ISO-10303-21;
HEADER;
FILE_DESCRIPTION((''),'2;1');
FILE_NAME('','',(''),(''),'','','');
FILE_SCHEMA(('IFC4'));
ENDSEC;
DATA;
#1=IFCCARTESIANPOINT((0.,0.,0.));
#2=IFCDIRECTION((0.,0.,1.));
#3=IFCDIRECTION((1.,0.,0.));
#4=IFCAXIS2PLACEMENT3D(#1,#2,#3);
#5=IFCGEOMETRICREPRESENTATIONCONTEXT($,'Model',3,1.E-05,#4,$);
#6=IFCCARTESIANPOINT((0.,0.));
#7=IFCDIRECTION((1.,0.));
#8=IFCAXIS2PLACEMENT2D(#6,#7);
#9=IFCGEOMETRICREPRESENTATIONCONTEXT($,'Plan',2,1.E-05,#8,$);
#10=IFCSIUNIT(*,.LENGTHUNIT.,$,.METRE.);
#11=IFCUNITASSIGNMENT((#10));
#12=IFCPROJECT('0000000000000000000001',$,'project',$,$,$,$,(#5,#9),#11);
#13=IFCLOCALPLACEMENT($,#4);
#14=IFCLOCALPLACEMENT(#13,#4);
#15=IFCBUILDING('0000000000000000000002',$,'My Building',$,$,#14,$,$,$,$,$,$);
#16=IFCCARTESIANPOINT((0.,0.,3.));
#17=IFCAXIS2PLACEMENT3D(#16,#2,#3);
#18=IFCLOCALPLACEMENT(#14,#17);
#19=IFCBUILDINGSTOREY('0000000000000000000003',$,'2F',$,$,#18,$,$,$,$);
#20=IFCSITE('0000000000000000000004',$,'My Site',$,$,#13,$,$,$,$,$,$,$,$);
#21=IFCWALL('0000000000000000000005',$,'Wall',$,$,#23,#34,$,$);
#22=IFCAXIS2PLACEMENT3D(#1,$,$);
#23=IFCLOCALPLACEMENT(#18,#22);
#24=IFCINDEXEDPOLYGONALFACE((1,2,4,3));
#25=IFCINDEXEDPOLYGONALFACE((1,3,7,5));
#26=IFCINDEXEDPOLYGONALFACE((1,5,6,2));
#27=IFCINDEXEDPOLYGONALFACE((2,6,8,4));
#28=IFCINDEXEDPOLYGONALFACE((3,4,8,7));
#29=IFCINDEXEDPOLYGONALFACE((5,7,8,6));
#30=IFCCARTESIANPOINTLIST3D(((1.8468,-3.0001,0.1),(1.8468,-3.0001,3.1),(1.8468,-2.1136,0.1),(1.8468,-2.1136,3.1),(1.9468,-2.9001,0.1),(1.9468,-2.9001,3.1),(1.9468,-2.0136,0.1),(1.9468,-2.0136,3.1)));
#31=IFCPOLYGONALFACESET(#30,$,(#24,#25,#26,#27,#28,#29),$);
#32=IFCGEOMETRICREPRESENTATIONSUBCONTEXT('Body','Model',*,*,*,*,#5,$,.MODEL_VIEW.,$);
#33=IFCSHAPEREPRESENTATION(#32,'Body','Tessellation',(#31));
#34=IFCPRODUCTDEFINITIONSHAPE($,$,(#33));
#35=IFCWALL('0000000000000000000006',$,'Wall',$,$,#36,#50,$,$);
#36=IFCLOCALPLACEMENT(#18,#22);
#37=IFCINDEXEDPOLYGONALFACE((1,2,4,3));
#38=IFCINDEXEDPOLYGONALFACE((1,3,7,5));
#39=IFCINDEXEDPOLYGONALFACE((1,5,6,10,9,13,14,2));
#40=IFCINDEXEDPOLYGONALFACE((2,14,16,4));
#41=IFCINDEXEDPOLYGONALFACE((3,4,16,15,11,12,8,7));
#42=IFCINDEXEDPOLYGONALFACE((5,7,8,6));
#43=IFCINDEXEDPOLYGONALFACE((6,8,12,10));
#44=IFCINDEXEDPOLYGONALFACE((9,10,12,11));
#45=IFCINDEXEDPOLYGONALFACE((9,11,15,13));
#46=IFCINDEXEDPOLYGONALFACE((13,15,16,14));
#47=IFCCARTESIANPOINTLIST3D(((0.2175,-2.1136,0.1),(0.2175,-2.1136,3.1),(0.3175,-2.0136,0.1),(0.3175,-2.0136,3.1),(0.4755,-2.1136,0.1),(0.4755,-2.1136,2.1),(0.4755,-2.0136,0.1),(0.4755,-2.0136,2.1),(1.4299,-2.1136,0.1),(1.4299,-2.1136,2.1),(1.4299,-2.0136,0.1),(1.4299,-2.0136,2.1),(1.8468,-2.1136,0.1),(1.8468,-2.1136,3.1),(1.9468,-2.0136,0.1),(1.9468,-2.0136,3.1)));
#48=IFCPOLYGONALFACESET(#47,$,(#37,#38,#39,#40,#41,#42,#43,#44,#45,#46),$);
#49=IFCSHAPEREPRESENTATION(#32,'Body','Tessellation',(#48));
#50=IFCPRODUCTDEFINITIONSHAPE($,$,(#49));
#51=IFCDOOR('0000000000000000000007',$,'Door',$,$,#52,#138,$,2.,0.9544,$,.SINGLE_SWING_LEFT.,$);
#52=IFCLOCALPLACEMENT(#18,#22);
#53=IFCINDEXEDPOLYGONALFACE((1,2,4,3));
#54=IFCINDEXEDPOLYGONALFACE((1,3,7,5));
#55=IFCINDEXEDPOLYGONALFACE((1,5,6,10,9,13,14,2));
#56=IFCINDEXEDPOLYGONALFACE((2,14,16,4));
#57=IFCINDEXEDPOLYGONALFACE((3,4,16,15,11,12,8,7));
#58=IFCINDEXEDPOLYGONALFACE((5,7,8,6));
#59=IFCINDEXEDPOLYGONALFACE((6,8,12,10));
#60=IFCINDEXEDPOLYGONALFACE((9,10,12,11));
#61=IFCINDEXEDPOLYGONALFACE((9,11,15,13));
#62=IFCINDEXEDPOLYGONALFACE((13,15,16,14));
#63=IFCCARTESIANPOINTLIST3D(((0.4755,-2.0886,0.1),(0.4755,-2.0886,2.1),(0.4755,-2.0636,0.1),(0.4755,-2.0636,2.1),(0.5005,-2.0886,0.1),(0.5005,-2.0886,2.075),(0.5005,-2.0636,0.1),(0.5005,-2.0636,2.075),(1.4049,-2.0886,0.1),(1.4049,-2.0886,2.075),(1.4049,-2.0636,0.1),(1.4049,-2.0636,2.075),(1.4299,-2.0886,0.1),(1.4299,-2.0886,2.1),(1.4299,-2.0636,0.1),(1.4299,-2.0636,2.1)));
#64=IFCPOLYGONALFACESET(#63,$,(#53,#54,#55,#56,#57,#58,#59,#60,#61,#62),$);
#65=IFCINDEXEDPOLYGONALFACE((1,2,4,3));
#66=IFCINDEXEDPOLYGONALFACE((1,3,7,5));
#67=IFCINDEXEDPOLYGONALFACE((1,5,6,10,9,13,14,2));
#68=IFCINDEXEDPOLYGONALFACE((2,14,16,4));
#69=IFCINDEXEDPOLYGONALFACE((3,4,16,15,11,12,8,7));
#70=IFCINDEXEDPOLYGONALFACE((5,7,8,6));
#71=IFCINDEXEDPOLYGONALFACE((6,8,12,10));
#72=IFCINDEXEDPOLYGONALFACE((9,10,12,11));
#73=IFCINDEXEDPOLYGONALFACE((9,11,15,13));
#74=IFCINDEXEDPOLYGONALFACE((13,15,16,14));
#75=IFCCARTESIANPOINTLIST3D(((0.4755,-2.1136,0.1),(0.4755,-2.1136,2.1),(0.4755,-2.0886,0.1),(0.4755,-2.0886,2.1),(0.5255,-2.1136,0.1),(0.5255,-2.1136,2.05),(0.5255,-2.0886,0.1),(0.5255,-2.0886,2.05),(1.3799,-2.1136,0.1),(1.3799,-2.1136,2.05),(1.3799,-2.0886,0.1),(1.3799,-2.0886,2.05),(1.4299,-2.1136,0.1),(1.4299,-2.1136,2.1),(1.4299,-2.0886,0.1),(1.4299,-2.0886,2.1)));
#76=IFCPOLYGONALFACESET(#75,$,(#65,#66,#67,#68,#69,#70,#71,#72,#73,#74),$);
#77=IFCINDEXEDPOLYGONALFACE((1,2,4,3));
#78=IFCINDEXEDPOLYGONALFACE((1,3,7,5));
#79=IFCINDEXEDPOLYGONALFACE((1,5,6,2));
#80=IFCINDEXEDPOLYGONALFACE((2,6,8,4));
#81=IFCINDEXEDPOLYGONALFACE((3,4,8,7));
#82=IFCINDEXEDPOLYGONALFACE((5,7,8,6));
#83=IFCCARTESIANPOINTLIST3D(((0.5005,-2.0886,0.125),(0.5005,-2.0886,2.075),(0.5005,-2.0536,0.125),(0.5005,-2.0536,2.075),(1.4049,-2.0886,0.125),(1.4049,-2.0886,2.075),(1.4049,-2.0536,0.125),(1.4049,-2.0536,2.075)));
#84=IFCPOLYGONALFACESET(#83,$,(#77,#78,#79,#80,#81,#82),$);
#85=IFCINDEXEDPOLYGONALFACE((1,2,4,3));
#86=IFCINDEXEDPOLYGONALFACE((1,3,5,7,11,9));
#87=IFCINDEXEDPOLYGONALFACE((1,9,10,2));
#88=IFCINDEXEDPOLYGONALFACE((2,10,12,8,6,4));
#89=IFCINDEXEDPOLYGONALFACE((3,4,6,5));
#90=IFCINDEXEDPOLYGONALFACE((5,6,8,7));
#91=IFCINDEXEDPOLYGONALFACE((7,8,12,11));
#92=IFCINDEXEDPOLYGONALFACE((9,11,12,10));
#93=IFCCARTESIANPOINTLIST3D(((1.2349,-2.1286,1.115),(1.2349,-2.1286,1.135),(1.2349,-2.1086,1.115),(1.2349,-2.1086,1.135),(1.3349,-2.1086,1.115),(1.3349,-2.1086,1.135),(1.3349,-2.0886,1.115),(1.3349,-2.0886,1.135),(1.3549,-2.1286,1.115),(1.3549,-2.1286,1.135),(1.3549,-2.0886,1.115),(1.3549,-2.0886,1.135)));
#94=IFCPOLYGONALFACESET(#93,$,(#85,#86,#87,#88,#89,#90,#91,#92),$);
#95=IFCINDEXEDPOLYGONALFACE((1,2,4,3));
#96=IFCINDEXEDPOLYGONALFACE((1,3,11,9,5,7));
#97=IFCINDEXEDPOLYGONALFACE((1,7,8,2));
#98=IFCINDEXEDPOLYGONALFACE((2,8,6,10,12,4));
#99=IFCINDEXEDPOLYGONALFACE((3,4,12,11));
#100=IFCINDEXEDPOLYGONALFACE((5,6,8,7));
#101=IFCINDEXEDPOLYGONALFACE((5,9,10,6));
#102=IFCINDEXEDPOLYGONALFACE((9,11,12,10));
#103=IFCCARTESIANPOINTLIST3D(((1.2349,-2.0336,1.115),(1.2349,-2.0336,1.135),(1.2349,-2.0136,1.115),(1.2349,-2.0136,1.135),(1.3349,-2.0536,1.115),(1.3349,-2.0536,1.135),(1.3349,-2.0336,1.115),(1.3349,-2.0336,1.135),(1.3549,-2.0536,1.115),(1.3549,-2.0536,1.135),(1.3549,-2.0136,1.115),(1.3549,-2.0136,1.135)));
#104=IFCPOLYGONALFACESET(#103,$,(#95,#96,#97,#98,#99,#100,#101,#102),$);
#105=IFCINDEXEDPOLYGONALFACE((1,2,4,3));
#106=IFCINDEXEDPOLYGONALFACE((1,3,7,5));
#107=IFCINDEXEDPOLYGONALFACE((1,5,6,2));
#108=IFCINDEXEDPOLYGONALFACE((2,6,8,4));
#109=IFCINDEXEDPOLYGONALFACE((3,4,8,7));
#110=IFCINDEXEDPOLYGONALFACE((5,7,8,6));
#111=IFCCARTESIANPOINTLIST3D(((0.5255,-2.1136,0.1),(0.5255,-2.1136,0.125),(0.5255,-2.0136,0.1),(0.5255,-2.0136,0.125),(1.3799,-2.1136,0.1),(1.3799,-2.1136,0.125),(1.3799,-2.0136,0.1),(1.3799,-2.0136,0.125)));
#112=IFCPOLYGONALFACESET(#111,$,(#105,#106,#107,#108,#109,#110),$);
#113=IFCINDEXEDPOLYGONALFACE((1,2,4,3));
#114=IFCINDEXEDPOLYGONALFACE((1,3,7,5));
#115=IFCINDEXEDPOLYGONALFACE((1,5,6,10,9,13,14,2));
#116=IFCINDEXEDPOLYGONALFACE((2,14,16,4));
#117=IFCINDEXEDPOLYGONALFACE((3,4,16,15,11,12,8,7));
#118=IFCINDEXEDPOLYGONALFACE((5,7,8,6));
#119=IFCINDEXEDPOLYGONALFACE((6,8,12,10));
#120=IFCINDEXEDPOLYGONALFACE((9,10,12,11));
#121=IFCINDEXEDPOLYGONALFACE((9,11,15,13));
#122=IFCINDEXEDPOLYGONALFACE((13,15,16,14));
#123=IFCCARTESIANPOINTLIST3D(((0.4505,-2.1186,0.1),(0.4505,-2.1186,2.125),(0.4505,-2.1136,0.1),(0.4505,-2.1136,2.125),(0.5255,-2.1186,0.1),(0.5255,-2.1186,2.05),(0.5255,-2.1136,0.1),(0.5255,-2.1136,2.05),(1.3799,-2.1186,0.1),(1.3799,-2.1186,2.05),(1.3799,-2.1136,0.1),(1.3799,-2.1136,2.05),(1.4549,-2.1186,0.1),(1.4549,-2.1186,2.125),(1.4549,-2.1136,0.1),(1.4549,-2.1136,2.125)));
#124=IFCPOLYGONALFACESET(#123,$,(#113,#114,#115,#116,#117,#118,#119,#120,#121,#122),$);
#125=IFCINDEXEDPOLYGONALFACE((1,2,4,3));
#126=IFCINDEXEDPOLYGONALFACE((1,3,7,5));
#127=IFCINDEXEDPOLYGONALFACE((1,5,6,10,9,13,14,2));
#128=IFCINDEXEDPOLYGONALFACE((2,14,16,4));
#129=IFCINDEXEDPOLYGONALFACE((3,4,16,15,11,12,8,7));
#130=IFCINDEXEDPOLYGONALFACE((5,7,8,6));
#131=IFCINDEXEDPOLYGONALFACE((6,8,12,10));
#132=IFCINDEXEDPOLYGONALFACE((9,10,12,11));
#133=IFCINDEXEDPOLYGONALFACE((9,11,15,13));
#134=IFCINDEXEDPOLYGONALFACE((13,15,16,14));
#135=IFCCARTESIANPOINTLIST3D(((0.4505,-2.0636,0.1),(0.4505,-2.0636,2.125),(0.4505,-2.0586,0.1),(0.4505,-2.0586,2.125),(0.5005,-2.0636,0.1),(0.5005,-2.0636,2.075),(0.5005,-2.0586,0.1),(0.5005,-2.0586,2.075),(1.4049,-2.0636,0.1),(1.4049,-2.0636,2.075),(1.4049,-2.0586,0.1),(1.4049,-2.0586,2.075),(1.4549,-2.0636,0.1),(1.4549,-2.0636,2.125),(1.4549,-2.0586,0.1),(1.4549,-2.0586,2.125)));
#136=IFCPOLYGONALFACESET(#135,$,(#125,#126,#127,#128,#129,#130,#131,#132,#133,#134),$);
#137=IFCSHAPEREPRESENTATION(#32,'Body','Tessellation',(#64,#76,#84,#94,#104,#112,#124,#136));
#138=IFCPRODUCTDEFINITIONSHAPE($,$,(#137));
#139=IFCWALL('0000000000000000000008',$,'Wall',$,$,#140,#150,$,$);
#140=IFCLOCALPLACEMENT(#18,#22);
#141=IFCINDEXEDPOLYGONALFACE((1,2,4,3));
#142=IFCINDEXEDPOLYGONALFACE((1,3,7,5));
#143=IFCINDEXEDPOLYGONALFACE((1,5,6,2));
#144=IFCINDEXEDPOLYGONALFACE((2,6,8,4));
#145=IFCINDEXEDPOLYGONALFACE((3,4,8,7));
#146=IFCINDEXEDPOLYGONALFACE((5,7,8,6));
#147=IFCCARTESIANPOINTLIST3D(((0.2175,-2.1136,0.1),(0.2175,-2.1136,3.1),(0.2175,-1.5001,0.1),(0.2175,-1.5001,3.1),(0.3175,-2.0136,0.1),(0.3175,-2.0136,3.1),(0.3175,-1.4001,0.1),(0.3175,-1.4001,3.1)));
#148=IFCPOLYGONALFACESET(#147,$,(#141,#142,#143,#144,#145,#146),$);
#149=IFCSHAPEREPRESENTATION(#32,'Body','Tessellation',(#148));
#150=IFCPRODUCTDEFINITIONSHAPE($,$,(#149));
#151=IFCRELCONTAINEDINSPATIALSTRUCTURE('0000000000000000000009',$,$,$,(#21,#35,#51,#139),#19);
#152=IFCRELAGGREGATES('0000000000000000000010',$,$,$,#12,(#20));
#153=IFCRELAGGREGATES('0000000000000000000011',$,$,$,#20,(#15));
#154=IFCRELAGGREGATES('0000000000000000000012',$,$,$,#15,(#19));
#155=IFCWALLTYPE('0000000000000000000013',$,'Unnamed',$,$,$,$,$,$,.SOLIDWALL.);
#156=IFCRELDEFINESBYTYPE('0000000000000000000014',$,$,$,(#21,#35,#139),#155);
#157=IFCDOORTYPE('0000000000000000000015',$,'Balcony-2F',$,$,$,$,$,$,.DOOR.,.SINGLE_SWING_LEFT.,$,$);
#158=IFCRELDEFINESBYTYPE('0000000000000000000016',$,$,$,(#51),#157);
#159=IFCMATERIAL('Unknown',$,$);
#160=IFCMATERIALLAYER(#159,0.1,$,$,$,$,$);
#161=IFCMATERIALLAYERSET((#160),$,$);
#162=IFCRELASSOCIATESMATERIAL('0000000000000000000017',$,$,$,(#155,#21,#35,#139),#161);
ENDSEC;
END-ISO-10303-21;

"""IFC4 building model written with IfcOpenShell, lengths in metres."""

from ifc_helpers import new_model, entity, si_unit, frame, origin_with_axes, origin_2d_with_axis, place, context, subcontext, project, spatial, line, indexed_curve, outline, extrude, shape, source, transform, mapped, material, layer, layer_set, layer_usage, type_object, type_shapes, element, fill, save


model = new_model("IFC4")

# Units and contexts
model_context = context("Model", 3, precision=1e-05, world=origin_with_axes())
plan_context = context("Plan", 2, precision=1e-05, world=origin_2d_with_axis())
body_context_1 = subcontext(model_context, "Body", "Model", "MODEL_VIEW")
body_context_2 = subcontext(plan_context, "Body", "Plan", "PLAN_VIEW")
ifc_project = project(units=[si_unit("LENGTHUNIT", "METRE")], contexts=[model_context, plan_context])

# Site, building, storey
site_placement = place(None, origin_with_axes())
site = spatial("IfcSite", under=ifc_project, at=site_placement, Name="My Site")
building_placement = place(site_placement, origin_with_axes())
building = spatial("IfcBuilding", under=site, at=building_placement, Name="My Building")
storey_placement = place(building_placement, frame((0.0, 0.0, 3.0), z_axis=(0.0, 0.0, 1.0), x_axis=(1.0, 0.0, 0.0)))
storey = spatial("IfcBuildingStorey", under=building, at=storey_placement, Name="2F")

# Shared definitions
ifc_material = material(Name="Unknown")
ifc_layer = layer(ifc_material, 0.1)
ifc_layer_set = layer_set([ifc_layer])
wall_type = type_object("IfcWallType", Name="Unnamed", PredefinedType="SOLIDWALL", material=ifc_layer_set)

# Wall
ifc_layer_usage_1 = layer_usage(ifc_layer_set, "AXIS2", "POSITIVE", 0.0)
wall_1_placement = place(storey_placement, frame((1.9468, -2.9001, 0.1), z_axis=(0.0, 0.0, 1.0), x_axis=(0.000001, 1.0, 0.0)))
element("IfcWall", 1, at=wall_1_placement, inside=storey, type_object=wall_type, material=ifc_layer_usage_1, Name="Wall", context=body_context_1, shape_type="SweptSolid", body=[
    extrude(outline(indexed_curve([(0.0, 0.0), (-0.1, 0.1), (0.7865, 0.1), (0.8865, 0.0)], segments=[line(1, 2, 3, 4, 1)])), origin_with_axes(), (0.0, 0.0, 1.0), 3.0),
])

# Wall, opening, door
ifc_layer_usage_2 = layer_usage(ifc_layer_set, "AXIS2", "POSITIVE", 0.0)
wall_2_placement = place(storey_placement, frame((1.9468, -2.0136, 0.1), z_axis=(0.0, 0.0, 1.0), x_axis=(-1.0, 0.0, 0.0)))
wall_2 = element("IfcWall", 2, at=wall_2_placement, inside=storey, type_object=wall_type, material=ifc_layer_usage_2, Name="Wall", context=body_context_1, shape_type="SweptSolid", body=[
    extrude(outline(indexed_curve([(0.0, 0.0), (0.1, 0.1), (1.7294, 0.1), (1.6294, 0.0)], segments=[line(1, 2, 3, 4, 1)])), origin_with_axes(), (0.0, 0.0, 1.0), 3.0),
])
shared_shape_1 = source(origin_with_axes(), body_context_1, "Body", "SweptSolid", [
    extrude(outline(indexed_curve([(0.0, 0.0), (0.9544, 0.0), (0.9544, 2.0), (0.0, 2.0)], segments=[line(1, 2, 3, 4, 1)])), frame((0.0, -0.6, 0.0), z_axis=(0.0, -1.0, 0.0), x_axis=(1.0, 0.0, 0.0)), (0.0, 0.0, -1.0), 1.2),
])
opening_1_placement = place(wall_2_placement, frame((1.4713, 0.1, 0.0), z_axis=(0.0, 0.0, 1.0), x_axis=(-1.0, 0.0, 0.0)))
opening_1 = element("IfcOpeningElement", 3, at=opening_1_placement, cuts=wall_2, PredefinedType="OPENING", context=body_context_1, shape_type="MappedRepresentation", body=[
    mapped(shared_shape_1, transform((0.0, 0.0, 0.0), x_axis=(1.0, 0.0, 0.0), y_axis=(0.0, 1.0, 0.0), z_axis=(0.0, 0.0, 1.0), scale=1.0)),
])
door_type_1 = type_object("IfcDoorType", Name="Balcony-2F", OperationType="SINGLE_SWING_LEFT", PredefinedType="DOOR")
shared_shape_2 = source(origin_with_axes(), body_context_1, "Body", "SweptSolid", [
    extrude(outline(indexed_curve([(0.0, 0.0), (0.0, 2.0), (0.9544, 2.0), (0.9544, 0.0), (0.9294, 0.0), (0.9294, 1.975), (0.025, 1.975), (0.025, 0.0)], segments=[line(1, 2, 3, 4, 5, 6, 7, 8, 1)])), frame((0.0, 0.025, 0.0), z_axis=(0.0, -1.0, 0.0), x_axis=(1.0, 0.0, 0.0)), (0.0, 0.0, -1.0), 0.025),
    extrude(outline(indexed_curve([(0.0, 0.0), (0.0, 2.0), (0.9544, 2.0), (0.9544, 0.0), (0.9044, 0.0), (0.9044, 1.95), (0.05, 1.95), (0.05, 0.0)], segments=[line(1, 2, 3, 4, 5, 6, 7, 8, 1)])), frame((0.0, 0.0, 0.0), z_axis=(0.0, -1.0, 0.0), x_axis=(1.0, 0.0, 0.0)), (0.0, 0.0, -1.0), 0.025),
    extrude(outline(indexed_curve([(0.0, 0.0), (0.9044, 0.0), (0.9044, 0.035), (0.0, 0.035)], segments=[line(1, 2, 3, 4, 1)])), frame((0.025, 0.025, 0.025), z_axis=(0.0, 0.0, 1.0), x_axis=(1.0, 0.0, 0.0)), (0.0, 0.0, 1.0), 1.95),
    extrude(outline(indexed_curve([(0.0, 0.0), (0.0, -0.04), (-0.12, -0.04), (-0.12, -0.02), (-0.02, -0.02), (-0.02, 0.0)], segments=[line(1, 2, 3, 4, 5, 6, 1)])), frame((0.8794, 0.025, 1.015), z_axis=(0.0, 0.0, 1.0), x_axis=(1.0, 0.0, 0.0)), (0.0, 0.0, 1.0), 0.02),
    extrude(outline(indexed_curve([(0.0, 0.0), (0.0, 0.04), (-0.12, 0.04), (-0.12, 0.02), (-0.02, 0.02), (-0.02, 0.0)], segments=[line(1, 2, 3, 4, 5, 6, 1)])), frame((0.8794, 0.06, 1.015), z_axis=(0.0, 0.0, 1.0), x_axis=(1.0, 0.0, 0.0)), (0.0, 0.0, 1.0), 0.02),
    extrude(outline(indexed_curve([(0.0, 0.0), (0.8544, 0.0), (0.8544, 0.1), (0.0, 0.1)], segments=[line(1, 2, 3, 4, 1)])), frame((0.05, 0.0, 0.0), z_axis=(0.0, 0.0, 1.0), x_axis=(1.0, 0.0, 0.0)), (0.0, 0.0, 1.0), 0.025),
    extrude(outline(indexed_curve([(0.0, 0.0), (0.0, 2.025), (1.0044, 2.025), (1.0044, 0.0), (0.9294, 0.0), (0.9294, 1.95), (0.075, 1.95), (0.075, 0.0)], segments=[line(1, 2, 3, 4, 5, 6, 7, 8, 1)])), frame((-0.025, -0.005, 0.0), z_axis=(0.0, -1.0, 0.0), x_axis=(1.0, 0.0, 0.0)), (0.0, 0.0, -1.0), 0.005),
    extrude(outline(indexed_curve([(0.0, 0.0), (0.0, 2.025), (1.0044, 2.025), (1.0044, 0.0), (0.9544, 0.0), (0.9544, 1.975), (0.05, 1.975), (0.05, 0.0)], segments=[line(1, 2, 3, 4, 5, 6, 7, 8, 1)])), frame((-0.025, 0.05, 0.0), z_axis=(0.0, -1.0, 0.0), x_axis=(1.0, 0.0, 0.0)), (0.0, 0.0, -1.0), 0.005),
])
shared_shape_3 = source(origin_with_axes(), body_context_2, "Body", "Curve2D", [
    entity("IfcIndexedPolyCurve", entity("IfcCartesianPointList2D", [[0.0, 0.0], [0.0, 0.05], [0.025, 0.05], [0.025, 0.025], [0.05, 0.025], [0.05, 0.0]]), [entity("IfcLineIndex", [1, 2, 3, 4, 5, 6, 1])]),
    entity("IfcIndexedPolyCurve", entity("IfcCartesianPointList2D", [[0.9544, 0.0], [0.9544, 0.05], [0.9294, 0.05], [0.9294, 0.025], [0.9044, 0.025], [0.9044, 0.0]]), [entity("IfcLineIndex", [1, 2, 3, 4, 5, 6, 1])]),
    entity("IfcTrimmedCurve", entity("IfcEllipse", entity("IfcAxis2Placement2D", entity("IfcCartesianPoint", [0.06, 0.05]), entity("IfcDirection", [1.0, 0.0])), 0.8694, 0.9044), [entity("IfcCartesianPoint", [0.9294, 0.05])], [entity("IfcCartesianPoint", [0.06, 0.9544])], True, "CARTESIAN"),
    entity("IfcIndexedPolyCurve", entity("IfcCartesianPointList2D", [[0.025, 0.05], [0.06, 0.05], [0.06, 0.9544], [0.025, 0.9544]]), [entity("IfcLineIndex", [1, 2, 3, 4, 1])]),
])
type_shapes(door_type_1, [shared_shape_2, shared_shape_3])
door_1_placement = place(opening_1_placement, frame((0.0, 0.0, 0.0), z_axis=(0.0, 0.0, 1.0), x_axis=(1.0, 0.0, 0.0)))
door_1 = element("IfcDoor", 4, at=door_1_placement, inside=storey, type_object=door_type_1, Name="Door", OperationType="SINGLE_SWING_LEFT", OverallHeight=2.0, OverallWidth=0.9544, shapes=[
    shape(body_context_1, "Body", "MappedRepresentation", [mapped(shared_shape_2, transform((0.0, 0.0, 0.0), x_axis=(1.0, 0.0, 0.0), y_axis=(0.0, 1.0, 0.0), z_axis=(0.0, 0.0, 1.0), scale=1.0))]),
    shape(body_context_2, "Body", "MappedRepresentation", [mapped(shared_shape_3, transform((0.0, 0.0, 0.0), x_axis=(1.0, 0.0, 0.0), y_axis=(0.0, 1.0, 0.0), z_axis=(0.0, 0.0, 1.0), scale=1.0))]),
])
fill(opening_1, door_1)

# Wall
ifc_layer_usage_3 = layer_usage(ifc_layer_set, "AXIS2", "POSITIVE", 0.0)
wall_3_placement = place(storey_placement, frame((0.3175, -2.0136, 0.1), z_axis=(0.0, 0.0, 1.0), x_axis=(0.0, 1.0, 0.0)))
element("IfcWall", 5, at=wall_3_placement, inside=storey, type_object=wall_type, material=ifc_layer_usage_3, Name="Wall", context=body_context_1, shape_type="SweptSolid", body=[
    extrude(outline(indexed_curve([(0.0, 0.0), (-0.1, 0.1), (0.5135, 0.1), (0.6135, 0.0)], segments=[line(1, 2, 3, 4, 1)])), origin_with_axes(), (0.0, 0.0, 1.0), 3.0),
])

save(model, "model.ifc")
